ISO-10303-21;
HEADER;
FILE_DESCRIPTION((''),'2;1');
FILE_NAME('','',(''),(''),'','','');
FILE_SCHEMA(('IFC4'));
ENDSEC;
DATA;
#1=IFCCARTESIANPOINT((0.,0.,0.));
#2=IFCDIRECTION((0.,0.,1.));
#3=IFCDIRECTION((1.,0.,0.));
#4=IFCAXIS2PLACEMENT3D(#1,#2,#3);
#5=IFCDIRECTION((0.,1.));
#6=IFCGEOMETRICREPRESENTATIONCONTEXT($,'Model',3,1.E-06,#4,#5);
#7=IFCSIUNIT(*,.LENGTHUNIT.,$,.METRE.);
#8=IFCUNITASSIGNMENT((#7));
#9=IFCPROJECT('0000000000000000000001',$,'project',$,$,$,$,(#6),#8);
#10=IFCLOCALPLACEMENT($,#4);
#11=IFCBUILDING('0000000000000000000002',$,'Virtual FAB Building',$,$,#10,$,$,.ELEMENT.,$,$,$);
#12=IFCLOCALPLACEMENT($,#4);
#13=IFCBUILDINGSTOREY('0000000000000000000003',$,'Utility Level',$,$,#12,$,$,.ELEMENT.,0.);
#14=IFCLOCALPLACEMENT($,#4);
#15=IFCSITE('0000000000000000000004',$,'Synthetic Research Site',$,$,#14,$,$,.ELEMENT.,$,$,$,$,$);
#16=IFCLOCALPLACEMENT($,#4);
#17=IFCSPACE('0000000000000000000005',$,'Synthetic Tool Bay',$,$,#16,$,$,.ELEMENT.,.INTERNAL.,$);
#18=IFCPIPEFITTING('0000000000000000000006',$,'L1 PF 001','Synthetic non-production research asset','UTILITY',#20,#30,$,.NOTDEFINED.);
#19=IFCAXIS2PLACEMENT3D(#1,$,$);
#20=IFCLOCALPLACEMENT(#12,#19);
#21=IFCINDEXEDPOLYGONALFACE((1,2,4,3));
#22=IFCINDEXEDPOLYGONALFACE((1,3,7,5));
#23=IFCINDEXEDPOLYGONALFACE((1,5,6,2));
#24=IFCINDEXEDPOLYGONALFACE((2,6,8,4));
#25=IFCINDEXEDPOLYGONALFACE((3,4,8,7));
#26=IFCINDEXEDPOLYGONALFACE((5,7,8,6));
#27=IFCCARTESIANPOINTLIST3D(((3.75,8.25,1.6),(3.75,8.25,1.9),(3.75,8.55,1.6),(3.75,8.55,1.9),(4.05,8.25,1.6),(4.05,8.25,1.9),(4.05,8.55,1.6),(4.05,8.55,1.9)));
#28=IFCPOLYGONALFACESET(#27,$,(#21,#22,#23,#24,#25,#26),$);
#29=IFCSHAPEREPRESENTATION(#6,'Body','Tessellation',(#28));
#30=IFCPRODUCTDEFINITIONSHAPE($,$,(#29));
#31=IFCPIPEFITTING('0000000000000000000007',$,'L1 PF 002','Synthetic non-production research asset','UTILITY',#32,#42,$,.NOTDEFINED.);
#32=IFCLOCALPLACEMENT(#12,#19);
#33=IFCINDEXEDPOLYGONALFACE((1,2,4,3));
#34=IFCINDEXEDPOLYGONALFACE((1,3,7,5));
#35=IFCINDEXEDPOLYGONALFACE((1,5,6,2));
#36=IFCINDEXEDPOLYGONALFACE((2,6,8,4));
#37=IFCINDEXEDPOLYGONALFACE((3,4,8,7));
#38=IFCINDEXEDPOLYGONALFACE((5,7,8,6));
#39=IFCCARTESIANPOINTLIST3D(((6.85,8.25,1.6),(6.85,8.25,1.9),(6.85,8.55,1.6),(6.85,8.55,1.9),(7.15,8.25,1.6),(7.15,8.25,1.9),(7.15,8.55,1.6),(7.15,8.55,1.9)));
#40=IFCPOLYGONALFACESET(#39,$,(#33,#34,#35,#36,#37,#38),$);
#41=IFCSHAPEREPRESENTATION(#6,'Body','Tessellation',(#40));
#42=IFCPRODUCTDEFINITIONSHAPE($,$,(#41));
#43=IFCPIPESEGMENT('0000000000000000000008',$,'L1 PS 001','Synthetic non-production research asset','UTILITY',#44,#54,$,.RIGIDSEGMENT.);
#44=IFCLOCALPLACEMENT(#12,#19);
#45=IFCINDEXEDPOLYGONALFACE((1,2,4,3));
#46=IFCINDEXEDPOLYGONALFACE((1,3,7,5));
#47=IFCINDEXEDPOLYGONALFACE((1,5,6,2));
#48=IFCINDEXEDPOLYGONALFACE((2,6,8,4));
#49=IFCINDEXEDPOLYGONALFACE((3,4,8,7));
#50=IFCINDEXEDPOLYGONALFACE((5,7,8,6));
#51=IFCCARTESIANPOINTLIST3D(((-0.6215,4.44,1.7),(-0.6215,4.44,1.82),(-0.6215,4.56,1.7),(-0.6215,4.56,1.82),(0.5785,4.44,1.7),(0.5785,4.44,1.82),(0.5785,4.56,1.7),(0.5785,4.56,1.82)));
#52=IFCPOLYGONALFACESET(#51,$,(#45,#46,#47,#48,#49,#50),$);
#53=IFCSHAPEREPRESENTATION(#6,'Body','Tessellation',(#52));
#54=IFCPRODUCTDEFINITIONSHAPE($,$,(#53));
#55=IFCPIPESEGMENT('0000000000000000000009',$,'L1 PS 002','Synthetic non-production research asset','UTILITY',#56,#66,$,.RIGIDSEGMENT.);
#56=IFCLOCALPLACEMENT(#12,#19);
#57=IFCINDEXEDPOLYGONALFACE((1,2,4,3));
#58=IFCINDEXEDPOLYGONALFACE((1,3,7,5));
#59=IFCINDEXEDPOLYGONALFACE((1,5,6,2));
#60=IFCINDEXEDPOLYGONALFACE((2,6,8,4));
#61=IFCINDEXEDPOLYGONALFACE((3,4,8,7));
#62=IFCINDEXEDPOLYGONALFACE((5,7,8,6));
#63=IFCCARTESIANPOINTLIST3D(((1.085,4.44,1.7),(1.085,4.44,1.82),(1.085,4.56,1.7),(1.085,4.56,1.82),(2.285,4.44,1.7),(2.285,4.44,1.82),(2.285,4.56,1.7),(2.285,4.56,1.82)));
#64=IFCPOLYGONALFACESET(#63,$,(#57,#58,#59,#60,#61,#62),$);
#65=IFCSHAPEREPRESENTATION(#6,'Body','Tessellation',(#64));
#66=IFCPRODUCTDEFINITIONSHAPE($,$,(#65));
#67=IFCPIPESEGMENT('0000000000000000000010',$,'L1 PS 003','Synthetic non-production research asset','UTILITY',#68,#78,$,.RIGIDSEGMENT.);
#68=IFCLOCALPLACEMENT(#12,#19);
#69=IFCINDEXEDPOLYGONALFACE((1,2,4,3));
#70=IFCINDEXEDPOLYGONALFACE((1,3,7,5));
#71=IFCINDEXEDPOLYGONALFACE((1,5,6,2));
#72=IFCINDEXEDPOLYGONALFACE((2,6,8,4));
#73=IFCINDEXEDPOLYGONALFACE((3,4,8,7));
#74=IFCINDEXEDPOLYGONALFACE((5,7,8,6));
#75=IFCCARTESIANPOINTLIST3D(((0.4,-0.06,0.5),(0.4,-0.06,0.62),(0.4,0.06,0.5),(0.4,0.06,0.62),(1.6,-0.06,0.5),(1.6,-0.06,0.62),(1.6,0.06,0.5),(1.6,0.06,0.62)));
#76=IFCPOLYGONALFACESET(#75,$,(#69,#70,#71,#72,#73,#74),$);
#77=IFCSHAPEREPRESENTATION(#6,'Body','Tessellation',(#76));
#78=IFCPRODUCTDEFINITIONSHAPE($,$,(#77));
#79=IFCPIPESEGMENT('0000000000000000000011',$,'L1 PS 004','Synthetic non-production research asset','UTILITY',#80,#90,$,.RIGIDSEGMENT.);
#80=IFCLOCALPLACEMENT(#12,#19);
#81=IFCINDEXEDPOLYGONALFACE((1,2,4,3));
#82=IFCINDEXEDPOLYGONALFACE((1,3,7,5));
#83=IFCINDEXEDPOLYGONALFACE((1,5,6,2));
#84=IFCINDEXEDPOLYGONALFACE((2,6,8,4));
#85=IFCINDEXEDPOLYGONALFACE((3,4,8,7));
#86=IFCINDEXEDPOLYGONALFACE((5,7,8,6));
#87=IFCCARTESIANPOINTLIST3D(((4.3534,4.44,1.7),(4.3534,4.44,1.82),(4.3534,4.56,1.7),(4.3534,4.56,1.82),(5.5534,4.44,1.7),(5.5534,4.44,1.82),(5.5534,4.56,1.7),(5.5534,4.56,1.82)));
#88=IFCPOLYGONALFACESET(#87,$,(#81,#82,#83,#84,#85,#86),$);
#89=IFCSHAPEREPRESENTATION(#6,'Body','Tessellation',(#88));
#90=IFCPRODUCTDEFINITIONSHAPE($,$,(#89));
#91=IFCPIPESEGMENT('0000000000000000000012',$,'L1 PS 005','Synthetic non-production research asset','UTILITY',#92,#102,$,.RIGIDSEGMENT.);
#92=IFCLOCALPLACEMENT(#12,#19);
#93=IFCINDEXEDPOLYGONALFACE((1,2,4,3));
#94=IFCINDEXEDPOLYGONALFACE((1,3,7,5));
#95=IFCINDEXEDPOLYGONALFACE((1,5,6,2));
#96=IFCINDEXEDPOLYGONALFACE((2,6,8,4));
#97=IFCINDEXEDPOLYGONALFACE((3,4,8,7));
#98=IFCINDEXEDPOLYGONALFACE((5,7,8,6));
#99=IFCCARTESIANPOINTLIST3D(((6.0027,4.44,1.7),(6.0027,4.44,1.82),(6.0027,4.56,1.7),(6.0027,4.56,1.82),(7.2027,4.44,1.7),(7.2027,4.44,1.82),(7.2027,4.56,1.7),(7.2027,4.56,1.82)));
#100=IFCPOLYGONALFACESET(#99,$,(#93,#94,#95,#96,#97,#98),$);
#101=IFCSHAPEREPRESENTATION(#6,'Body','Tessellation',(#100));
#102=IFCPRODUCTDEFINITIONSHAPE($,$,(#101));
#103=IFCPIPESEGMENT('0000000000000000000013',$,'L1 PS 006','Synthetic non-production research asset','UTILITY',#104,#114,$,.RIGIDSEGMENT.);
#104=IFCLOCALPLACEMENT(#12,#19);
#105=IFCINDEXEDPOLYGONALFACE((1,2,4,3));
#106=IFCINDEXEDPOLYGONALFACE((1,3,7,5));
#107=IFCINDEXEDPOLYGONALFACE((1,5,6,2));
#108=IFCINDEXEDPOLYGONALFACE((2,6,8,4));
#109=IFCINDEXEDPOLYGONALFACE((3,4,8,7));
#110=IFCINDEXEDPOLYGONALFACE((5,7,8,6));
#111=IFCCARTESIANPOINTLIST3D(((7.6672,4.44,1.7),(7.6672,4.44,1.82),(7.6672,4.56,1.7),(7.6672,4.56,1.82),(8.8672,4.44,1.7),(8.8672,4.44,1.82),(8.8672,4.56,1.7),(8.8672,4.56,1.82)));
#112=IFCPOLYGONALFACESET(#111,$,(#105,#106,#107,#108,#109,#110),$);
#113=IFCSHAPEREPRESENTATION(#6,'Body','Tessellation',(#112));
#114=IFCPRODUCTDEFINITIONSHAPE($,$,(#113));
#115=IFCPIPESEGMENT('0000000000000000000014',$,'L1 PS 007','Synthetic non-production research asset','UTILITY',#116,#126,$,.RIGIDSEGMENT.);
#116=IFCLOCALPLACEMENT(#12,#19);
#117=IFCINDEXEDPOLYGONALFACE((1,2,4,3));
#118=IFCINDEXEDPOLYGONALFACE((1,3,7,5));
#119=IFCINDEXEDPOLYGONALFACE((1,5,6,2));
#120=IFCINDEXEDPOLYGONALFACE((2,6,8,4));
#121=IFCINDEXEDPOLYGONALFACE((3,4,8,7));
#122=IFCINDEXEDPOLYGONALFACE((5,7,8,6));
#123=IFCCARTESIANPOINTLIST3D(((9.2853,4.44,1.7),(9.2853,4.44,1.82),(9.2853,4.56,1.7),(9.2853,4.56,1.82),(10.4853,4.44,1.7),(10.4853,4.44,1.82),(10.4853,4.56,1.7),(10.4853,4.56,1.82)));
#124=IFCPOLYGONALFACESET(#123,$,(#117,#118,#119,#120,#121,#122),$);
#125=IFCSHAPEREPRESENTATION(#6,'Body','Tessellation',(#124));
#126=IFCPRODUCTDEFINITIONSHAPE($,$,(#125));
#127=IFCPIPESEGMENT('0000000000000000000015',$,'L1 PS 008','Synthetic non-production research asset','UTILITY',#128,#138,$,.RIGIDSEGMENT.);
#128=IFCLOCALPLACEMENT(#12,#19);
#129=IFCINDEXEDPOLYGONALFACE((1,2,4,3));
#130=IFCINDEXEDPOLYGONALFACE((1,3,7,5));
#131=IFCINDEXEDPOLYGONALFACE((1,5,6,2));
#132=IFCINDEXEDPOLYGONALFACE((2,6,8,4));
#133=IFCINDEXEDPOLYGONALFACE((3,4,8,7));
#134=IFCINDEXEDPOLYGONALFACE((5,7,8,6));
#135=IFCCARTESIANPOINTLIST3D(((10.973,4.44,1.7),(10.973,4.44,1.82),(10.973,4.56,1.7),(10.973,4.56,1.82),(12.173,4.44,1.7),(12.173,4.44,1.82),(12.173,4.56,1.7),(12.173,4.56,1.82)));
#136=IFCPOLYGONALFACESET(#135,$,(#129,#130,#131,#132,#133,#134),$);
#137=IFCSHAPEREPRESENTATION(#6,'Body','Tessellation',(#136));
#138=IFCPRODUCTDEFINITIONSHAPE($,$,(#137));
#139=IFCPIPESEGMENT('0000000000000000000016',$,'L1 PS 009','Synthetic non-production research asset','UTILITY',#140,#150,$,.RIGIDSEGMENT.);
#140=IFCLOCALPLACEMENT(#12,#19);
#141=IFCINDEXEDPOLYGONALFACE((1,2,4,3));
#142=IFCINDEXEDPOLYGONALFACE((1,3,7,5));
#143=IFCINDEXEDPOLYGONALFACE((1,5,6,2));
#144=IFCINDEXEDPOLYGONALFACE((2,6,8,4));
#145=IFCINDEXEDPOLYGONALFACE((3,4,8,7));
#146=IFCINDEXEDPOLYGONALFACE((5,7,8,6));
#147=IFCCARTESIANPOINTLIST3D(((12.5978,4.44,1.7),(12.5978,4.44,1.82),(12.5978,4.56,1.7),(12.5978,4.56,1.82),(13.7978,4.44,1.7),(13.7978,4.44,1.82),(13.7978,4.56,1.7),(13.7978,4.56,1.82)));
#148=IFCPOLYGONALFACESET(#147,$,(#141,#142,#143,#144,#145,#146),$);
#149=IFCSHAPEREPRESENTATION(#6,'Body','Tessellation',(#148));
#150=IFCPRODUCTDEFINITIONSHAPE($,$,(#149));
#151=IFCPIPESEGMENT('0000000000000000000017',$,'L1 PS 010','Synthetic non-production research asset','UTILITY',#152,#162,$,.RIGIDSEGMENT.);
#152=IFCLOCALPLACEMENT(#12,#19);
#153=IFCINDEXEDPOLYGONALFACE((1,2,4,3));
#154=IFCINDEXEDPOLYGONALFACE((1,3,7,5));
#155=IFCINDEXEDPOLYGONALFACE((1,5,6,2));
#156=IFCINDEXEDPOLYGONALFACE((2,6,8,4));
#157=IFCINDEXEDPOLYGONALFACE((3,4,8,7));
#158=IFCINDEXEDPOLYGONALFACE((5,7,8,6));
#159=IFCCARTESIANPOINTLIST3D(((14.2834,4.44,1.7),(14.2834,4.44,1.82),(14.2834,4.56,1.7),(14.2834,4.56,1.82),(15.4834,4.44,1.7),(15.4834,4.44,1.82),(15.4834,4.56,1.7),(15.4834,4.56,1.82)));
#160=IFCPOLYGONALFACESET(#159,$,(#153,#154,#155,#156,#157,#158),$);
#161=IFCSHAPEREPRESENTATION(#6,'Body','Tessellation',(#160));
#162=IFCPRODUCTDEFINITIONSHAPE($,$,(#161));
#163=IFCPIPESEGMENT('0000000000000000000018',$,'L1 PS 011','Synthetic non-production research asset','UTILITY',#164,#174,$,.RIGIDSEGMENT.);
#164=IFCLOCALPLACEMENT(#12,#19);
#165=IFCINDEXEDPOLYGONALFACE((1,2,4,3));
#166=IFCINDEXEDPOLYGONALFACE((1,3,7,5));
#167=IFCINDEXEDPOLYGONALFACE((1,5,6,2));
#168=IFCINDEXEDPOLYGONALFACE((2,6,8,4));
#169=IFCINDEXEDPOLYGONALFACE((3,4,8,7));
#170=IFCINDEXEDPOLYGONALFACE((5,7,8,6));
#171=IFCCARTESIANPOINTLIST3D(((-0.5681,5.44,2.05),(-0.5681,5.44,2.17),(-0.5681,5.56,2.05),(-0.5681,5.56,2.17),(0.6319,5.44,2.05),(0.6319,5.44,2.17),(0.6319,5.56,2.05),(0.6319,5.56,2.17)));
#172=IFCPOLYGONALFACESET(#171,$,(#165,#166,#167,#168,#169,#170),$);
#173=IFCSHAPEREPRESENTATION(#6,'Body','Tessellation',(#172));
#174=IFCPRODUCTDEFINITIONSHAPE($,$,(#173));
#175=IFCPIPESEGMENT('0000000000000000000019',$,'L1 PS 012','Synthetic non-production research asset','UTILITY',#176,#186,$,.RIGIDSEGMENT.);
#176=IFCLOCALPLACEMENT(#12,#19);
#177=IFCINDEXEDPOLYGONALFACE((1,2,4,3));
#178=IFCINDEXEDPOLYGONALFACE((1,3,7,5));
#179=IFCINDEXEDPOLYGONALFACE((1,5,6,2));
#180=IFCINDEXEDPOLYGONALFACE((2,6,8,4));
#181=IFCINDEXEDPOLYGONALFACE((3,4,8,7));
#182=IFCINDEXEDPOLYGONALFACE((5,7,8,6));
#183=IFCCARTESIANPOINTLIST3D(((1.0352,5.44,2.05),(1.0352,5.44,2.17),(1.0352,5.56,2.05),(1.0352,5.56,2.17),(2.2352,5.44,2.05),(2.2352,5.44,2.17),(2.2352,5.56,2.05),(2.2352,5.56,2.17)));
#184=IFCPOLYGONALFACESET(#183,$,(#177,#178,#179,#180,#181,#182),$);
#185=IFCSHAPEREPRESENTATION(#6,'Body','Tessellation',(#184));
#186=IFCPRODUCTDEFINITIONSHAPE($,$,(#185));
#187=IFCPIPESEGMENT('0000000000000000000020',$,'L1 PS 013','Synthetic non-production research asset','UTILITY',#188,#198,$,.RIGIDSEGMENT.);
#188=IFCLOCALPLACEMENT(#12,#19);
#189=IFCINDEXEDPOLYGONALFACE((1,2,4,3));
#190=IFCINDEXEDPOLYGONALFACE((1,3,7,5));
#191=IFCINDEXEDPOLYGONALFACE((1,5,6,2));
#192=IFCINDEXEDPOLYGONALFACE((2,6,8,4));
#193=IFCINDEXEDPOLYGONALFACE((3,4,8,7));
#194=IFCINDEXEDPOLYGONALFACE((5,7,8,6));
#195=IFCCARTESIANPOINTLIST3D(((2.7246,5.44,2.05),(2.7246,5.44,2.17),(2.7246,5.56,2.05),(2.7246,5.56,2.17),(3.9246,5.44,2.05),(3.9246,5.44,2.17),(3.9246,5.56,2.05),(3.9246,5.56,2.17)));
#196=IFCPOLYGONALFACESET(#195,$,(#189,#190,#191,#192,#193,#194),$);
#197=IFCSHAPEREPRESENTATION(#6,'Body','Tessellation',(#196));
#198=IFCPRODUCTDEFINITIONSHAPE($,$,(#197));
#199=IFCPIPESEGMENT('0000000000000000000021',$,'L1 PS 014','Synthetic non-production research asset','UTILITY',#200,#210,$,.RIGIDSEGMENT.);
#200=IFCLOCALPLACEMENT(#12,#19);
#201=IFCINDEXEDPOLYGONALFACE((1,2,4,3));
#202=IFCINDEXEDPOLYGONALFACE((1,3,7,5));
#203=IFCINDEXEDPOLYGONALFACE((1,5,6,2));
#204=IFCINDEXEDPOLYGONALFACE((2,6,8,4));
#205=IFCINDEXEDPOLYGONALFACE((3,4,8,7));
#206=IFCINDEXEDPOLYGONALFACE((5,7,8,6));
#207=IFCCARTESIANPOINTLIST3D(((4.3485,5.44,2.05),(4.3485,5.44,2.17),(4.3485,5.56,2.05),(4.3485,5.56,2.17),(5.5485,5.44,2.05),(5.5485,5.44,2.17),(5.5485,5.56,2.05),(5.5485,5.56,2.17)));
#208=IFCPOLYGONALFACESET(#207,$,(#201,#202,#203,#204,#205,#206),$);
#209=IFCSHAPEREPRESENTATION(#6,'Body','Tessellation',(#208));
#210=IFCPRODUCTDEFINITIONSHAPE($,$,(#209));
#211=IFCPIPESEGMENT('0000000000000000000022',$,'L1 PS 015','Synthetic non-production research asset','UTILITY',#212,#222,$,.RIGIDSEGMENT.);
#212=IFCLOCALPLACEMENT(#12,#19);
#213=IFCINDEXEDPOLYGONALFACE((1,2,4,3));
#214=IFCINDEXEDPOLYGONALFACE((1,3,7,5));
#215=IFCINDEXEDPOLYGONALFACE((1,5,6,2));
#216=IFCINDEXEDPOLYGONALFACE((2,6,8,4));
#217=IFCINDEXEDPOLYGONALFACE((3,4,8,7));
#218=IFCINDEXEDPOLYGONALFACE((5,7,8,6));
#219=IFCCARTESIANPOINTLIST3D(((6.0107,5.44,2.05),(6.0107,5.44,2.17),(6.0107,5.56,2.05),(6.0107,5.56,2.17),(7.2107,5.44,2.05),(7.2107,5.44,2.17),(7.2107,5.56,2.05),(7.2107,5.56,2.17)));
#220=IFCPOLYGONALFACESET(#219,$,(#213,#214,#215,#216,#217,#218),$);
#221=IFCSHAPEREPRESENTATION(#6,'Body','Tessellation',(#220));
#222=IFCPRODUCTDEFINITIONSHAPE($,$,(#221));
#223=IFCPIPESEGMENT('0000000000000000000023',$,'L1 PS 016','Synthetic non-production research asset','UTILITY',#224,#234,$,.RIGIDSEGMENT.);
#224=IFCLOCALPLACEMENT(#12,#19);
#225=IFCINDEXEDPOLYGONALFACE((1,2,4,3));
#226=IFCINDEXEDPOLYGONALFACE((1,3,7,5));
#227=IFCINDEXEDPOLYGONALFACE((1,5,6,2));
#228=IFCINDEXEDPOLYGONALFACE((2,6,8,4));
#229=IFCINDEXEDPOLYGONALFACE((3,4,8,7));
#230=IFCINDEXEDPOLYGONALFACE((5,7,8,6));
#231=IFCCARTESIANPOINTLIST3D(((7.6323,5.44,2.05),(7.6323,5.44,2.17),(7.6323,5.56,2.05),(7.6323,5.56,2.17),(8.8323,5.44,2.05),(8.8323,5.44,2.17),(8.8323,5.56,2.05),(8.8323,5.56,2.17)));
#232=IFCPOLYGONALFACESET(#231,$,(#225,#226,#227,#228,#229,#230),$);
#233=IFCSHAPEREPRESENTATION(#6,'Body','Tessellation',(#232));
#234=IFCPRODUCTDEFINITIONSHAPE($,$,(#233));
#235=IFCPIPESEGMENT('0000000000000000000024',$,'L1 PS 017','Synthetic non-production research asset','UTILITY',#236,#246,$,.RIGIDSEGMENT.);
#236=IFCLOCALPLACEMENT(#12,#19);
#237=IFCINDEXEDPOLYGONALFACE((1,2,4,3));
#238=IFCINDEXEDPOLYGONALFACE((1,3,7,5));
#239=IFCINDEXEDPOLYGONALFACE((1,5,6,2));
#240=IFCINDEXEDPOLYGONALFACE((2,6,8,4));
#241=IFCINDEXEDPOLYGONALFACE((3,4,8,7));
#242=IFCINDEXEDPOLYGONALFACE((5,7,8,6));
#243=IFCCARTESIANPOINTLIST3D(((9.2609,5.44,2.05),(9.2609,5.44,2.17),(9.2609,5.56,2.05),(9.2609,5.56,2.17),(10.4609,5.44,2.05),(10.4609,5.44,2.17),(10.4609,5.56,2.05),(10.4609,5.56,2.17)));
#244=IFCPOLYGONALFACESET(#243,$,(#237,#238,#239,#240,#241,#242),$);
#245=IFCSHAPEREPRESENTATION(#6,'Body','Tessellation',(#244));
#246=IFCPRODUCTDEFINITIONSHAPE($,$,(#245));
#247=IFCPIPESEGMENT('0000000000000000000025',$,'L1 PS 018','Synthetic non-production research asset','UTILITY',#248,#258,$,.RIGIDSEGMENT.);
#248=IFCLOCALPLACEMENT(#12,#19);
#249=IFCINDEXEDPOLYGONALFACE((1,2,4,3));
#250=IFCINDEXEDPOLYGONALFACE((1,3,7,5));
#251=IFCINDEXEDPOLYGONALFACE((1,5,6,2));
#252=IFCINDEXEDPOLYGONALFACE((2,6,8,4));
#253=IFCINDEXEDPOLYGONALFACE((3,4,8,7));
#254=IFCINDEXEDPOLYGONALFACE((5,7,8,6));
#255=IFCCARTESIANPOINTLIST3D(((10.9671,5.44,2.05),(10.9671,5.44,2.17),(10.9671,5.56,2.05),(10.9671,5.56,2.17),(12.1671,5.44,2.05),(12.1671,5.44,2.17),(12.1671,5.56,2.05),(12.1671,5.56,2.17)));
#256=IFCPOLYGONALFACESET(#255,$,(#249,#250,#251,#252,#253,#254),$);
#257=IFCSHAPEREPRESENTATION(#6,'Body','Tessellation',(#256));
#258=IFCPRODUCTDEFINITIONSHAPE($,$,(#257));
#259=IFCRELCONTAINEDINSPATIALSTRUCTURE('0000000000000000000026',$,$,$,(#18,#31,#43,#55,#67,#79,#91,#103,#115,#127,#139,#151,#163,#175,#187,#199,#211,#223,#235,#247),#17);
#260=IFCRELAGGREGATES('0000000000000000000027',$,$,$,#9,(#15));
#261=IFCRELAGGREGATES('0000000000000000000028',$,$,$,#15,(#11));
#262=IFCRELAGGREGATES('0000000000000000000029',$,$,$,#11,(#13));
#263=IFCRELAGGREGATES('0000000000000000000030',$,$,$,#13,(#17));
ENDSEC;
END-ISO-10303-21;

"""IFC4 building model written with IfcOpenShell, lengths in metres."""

from ifc_helpers import new_model, si_unit, direction, frame, origin_with_axes, origin_2d_with_axis, place, context, project, spatial, rectangle, extrude, element, save


model = new_model("IFC4")

# Units and contexts
model_context = context("Model", 3, precision=1e-06, world=origin_with_axes(), true_north=direction((0.0, 1.0)))
ifc_project = project(units=[si_unit("LENGTHUNIT", "METRE")], contexts=[model_context])

# Site, building, storey, space
site_placement = place(None, origin_with_axes())
site = spatial("IfcSite", under=ifc_project, at=site_placement, Name="Synthetic Research Site", CompositionType="ELEMENT")
building_placement = place(None, origin_with_axes())
building = spatial("IfcBuilding", under=site, at=building_placement, Name="Virtual FAB Building", CompositionType="ELEMENT")
storey_placement = place(None, origin_with_axes())
storey = spatial("IfcBuildingStorey", under=building, at=storey_placement, Name="Utility Level", CompositionType="ELEMENT", Elevation=0.0)
space_placement = place(None, origin_with_axes())
space = spatial("IfcSpace", under=storey, at=space_placement, Name="Synthetic Tool Bay", CompositionType="ELEMENT", PredefinedType="INTERNAL")

# Pipe fittings
for number, where, z_axis, x_axis, name in (
    (1, (3.9, 8.4, 1.6), (0.0, 0.0, 1.0), (1.0, 0.0, 0.0), "L1 PF 001"),
    (2, (7.0, 8.4, 1.6), (0.0, 0.0, 1.0), (1.0, 0.0, 0.0), "L1 PF 002"),
):
    element("IfcPipeFitting", number, at=place(None, frame(where, z_axis=z_axis, x_axis=x_axis)), inside=space, Name=name, Description="Synthetic non-production research asset", ObjectType="UTILITY", PredefinedType="NOTDEFINED", context=model_context, shape_type="SweptSolid", body=[
        extrude(rectangle(XDim=0.3, YDim=0.3, at=origin_2d_with_axis()), origin_with_axes(), (0.0, 0.0, 1.0), 0.3),
    ])

# Pipe segments
for number, where, z_axis, x_axis, name in (
    (3, (-0.0215, 4.5, 1.7), (0.0, 0.0, 1.0), (1.0, 0.0, 0.0), "L1 PS 001"),
    (4, (1.685, 4.5, 1.7), (0.0, 0.0, 1.0), (1.0, 0.0, 0.0), "L1 PS 002"),
    (5, (1.0, 0.0, 0.5), (0.0, 0.0, 1.0), (1.0, 0.0, 0.0), "L1 PS 003"),
    (6, (4.9534, 4.5, 1.7), (0.0, 0.0, 1.0), (1.0, 0.0, 0.0), "L1 PS 004"),
    (7, (6.6027, 4.5, 1.7), (0.0, 0.0, 1.0), (1.0, 0.0, 0.0), "L1 PS 005"),
    (8, (8.2672, 4.5, 1.7), (0.0, 0.0, 1.0), (1.0, 0.0, 0.0), "L1 PS 006"),
    (9, (9.8853, 4.5, 1.7), (0.0, 0.0, 1.0), (1.0, 0.0, 0.0), "L1 PS 007"),
    (10, (11.573, 4.5, 1.7), (0.0, 0.0, 1.0), (1.0, 0.0, 0.0), "L1 PS 008"),
    (11, (13.1978, 4.5, 1.7), (0.0, 0.0, 1.0), (1.0, 0.0, 0.0), "L1 PS 009"),
    (12, (14.8834, 4.5, 1.7), (0.0, 0.0, 1.0), (1.0, 0.0, 0.0), "L1 PS 010"),
    (13, (0.0319, 5.5, 2.05), (0.0, 0.0, 1.0), (1.0, 0.0, 0.0), "L1 PS 011"),
    (14, (1.6352, 5.5, 2.05), (0.0, 0.0, 1.0), (1.0, 0.0, 0.0), "L1 PS 012"),
    (15, (3.3246, 5.5, 2.05), (0.0, 0.0, 1.0), (1.0, 0.0, 0.0), "L1 PS 013"),
    (16, (4.9485, 5.5, 2.05), (0.0, 0.0, 1.0), (1.0, 0.0, 0.0), "L1 PS 014"),
    (17, (6.6107, 5.5, 2.05), (0.0, 0.0, 1.0), (1.0, 0.0, 0.0), "L1 PS 015"),
    (18, (8.2323, 5.5, 2.05), (0.0, 0.0, 1.0), (1.0, 0.0, 0.0), "L1 PS 016"),
    (19, (9.8609, 5.5, 2.05), (0.0, 0.0, 1.0), (1.0, 0.0, 0.0), "L1 PS 017"),
    (20, (11.5671, 5.5, 2.05), (0.0, 0.0, 1.0), (1.0, 0.0, 0.0), "L1 PS 018"),
):
    element("IfcPipeSegment", number, at=place(None, frame(where, z_axis=z_axis, x_axis=x_axis)), inside=space, Name=name, Description="Synthetic non-production research asset", ObjectType="UTILITY", PredefinedType="RIGIDSEGMENT", context=model_context, shape_type="SweptSolid", body=[
        extrude(rectangle(XDim=1.2, YDim=0.12, at=origin_2d_with_axis()), origin_with_axes(), (0.0, 0.0, 1.0), 0.12),
    ])

save(model, "model.ifc")
